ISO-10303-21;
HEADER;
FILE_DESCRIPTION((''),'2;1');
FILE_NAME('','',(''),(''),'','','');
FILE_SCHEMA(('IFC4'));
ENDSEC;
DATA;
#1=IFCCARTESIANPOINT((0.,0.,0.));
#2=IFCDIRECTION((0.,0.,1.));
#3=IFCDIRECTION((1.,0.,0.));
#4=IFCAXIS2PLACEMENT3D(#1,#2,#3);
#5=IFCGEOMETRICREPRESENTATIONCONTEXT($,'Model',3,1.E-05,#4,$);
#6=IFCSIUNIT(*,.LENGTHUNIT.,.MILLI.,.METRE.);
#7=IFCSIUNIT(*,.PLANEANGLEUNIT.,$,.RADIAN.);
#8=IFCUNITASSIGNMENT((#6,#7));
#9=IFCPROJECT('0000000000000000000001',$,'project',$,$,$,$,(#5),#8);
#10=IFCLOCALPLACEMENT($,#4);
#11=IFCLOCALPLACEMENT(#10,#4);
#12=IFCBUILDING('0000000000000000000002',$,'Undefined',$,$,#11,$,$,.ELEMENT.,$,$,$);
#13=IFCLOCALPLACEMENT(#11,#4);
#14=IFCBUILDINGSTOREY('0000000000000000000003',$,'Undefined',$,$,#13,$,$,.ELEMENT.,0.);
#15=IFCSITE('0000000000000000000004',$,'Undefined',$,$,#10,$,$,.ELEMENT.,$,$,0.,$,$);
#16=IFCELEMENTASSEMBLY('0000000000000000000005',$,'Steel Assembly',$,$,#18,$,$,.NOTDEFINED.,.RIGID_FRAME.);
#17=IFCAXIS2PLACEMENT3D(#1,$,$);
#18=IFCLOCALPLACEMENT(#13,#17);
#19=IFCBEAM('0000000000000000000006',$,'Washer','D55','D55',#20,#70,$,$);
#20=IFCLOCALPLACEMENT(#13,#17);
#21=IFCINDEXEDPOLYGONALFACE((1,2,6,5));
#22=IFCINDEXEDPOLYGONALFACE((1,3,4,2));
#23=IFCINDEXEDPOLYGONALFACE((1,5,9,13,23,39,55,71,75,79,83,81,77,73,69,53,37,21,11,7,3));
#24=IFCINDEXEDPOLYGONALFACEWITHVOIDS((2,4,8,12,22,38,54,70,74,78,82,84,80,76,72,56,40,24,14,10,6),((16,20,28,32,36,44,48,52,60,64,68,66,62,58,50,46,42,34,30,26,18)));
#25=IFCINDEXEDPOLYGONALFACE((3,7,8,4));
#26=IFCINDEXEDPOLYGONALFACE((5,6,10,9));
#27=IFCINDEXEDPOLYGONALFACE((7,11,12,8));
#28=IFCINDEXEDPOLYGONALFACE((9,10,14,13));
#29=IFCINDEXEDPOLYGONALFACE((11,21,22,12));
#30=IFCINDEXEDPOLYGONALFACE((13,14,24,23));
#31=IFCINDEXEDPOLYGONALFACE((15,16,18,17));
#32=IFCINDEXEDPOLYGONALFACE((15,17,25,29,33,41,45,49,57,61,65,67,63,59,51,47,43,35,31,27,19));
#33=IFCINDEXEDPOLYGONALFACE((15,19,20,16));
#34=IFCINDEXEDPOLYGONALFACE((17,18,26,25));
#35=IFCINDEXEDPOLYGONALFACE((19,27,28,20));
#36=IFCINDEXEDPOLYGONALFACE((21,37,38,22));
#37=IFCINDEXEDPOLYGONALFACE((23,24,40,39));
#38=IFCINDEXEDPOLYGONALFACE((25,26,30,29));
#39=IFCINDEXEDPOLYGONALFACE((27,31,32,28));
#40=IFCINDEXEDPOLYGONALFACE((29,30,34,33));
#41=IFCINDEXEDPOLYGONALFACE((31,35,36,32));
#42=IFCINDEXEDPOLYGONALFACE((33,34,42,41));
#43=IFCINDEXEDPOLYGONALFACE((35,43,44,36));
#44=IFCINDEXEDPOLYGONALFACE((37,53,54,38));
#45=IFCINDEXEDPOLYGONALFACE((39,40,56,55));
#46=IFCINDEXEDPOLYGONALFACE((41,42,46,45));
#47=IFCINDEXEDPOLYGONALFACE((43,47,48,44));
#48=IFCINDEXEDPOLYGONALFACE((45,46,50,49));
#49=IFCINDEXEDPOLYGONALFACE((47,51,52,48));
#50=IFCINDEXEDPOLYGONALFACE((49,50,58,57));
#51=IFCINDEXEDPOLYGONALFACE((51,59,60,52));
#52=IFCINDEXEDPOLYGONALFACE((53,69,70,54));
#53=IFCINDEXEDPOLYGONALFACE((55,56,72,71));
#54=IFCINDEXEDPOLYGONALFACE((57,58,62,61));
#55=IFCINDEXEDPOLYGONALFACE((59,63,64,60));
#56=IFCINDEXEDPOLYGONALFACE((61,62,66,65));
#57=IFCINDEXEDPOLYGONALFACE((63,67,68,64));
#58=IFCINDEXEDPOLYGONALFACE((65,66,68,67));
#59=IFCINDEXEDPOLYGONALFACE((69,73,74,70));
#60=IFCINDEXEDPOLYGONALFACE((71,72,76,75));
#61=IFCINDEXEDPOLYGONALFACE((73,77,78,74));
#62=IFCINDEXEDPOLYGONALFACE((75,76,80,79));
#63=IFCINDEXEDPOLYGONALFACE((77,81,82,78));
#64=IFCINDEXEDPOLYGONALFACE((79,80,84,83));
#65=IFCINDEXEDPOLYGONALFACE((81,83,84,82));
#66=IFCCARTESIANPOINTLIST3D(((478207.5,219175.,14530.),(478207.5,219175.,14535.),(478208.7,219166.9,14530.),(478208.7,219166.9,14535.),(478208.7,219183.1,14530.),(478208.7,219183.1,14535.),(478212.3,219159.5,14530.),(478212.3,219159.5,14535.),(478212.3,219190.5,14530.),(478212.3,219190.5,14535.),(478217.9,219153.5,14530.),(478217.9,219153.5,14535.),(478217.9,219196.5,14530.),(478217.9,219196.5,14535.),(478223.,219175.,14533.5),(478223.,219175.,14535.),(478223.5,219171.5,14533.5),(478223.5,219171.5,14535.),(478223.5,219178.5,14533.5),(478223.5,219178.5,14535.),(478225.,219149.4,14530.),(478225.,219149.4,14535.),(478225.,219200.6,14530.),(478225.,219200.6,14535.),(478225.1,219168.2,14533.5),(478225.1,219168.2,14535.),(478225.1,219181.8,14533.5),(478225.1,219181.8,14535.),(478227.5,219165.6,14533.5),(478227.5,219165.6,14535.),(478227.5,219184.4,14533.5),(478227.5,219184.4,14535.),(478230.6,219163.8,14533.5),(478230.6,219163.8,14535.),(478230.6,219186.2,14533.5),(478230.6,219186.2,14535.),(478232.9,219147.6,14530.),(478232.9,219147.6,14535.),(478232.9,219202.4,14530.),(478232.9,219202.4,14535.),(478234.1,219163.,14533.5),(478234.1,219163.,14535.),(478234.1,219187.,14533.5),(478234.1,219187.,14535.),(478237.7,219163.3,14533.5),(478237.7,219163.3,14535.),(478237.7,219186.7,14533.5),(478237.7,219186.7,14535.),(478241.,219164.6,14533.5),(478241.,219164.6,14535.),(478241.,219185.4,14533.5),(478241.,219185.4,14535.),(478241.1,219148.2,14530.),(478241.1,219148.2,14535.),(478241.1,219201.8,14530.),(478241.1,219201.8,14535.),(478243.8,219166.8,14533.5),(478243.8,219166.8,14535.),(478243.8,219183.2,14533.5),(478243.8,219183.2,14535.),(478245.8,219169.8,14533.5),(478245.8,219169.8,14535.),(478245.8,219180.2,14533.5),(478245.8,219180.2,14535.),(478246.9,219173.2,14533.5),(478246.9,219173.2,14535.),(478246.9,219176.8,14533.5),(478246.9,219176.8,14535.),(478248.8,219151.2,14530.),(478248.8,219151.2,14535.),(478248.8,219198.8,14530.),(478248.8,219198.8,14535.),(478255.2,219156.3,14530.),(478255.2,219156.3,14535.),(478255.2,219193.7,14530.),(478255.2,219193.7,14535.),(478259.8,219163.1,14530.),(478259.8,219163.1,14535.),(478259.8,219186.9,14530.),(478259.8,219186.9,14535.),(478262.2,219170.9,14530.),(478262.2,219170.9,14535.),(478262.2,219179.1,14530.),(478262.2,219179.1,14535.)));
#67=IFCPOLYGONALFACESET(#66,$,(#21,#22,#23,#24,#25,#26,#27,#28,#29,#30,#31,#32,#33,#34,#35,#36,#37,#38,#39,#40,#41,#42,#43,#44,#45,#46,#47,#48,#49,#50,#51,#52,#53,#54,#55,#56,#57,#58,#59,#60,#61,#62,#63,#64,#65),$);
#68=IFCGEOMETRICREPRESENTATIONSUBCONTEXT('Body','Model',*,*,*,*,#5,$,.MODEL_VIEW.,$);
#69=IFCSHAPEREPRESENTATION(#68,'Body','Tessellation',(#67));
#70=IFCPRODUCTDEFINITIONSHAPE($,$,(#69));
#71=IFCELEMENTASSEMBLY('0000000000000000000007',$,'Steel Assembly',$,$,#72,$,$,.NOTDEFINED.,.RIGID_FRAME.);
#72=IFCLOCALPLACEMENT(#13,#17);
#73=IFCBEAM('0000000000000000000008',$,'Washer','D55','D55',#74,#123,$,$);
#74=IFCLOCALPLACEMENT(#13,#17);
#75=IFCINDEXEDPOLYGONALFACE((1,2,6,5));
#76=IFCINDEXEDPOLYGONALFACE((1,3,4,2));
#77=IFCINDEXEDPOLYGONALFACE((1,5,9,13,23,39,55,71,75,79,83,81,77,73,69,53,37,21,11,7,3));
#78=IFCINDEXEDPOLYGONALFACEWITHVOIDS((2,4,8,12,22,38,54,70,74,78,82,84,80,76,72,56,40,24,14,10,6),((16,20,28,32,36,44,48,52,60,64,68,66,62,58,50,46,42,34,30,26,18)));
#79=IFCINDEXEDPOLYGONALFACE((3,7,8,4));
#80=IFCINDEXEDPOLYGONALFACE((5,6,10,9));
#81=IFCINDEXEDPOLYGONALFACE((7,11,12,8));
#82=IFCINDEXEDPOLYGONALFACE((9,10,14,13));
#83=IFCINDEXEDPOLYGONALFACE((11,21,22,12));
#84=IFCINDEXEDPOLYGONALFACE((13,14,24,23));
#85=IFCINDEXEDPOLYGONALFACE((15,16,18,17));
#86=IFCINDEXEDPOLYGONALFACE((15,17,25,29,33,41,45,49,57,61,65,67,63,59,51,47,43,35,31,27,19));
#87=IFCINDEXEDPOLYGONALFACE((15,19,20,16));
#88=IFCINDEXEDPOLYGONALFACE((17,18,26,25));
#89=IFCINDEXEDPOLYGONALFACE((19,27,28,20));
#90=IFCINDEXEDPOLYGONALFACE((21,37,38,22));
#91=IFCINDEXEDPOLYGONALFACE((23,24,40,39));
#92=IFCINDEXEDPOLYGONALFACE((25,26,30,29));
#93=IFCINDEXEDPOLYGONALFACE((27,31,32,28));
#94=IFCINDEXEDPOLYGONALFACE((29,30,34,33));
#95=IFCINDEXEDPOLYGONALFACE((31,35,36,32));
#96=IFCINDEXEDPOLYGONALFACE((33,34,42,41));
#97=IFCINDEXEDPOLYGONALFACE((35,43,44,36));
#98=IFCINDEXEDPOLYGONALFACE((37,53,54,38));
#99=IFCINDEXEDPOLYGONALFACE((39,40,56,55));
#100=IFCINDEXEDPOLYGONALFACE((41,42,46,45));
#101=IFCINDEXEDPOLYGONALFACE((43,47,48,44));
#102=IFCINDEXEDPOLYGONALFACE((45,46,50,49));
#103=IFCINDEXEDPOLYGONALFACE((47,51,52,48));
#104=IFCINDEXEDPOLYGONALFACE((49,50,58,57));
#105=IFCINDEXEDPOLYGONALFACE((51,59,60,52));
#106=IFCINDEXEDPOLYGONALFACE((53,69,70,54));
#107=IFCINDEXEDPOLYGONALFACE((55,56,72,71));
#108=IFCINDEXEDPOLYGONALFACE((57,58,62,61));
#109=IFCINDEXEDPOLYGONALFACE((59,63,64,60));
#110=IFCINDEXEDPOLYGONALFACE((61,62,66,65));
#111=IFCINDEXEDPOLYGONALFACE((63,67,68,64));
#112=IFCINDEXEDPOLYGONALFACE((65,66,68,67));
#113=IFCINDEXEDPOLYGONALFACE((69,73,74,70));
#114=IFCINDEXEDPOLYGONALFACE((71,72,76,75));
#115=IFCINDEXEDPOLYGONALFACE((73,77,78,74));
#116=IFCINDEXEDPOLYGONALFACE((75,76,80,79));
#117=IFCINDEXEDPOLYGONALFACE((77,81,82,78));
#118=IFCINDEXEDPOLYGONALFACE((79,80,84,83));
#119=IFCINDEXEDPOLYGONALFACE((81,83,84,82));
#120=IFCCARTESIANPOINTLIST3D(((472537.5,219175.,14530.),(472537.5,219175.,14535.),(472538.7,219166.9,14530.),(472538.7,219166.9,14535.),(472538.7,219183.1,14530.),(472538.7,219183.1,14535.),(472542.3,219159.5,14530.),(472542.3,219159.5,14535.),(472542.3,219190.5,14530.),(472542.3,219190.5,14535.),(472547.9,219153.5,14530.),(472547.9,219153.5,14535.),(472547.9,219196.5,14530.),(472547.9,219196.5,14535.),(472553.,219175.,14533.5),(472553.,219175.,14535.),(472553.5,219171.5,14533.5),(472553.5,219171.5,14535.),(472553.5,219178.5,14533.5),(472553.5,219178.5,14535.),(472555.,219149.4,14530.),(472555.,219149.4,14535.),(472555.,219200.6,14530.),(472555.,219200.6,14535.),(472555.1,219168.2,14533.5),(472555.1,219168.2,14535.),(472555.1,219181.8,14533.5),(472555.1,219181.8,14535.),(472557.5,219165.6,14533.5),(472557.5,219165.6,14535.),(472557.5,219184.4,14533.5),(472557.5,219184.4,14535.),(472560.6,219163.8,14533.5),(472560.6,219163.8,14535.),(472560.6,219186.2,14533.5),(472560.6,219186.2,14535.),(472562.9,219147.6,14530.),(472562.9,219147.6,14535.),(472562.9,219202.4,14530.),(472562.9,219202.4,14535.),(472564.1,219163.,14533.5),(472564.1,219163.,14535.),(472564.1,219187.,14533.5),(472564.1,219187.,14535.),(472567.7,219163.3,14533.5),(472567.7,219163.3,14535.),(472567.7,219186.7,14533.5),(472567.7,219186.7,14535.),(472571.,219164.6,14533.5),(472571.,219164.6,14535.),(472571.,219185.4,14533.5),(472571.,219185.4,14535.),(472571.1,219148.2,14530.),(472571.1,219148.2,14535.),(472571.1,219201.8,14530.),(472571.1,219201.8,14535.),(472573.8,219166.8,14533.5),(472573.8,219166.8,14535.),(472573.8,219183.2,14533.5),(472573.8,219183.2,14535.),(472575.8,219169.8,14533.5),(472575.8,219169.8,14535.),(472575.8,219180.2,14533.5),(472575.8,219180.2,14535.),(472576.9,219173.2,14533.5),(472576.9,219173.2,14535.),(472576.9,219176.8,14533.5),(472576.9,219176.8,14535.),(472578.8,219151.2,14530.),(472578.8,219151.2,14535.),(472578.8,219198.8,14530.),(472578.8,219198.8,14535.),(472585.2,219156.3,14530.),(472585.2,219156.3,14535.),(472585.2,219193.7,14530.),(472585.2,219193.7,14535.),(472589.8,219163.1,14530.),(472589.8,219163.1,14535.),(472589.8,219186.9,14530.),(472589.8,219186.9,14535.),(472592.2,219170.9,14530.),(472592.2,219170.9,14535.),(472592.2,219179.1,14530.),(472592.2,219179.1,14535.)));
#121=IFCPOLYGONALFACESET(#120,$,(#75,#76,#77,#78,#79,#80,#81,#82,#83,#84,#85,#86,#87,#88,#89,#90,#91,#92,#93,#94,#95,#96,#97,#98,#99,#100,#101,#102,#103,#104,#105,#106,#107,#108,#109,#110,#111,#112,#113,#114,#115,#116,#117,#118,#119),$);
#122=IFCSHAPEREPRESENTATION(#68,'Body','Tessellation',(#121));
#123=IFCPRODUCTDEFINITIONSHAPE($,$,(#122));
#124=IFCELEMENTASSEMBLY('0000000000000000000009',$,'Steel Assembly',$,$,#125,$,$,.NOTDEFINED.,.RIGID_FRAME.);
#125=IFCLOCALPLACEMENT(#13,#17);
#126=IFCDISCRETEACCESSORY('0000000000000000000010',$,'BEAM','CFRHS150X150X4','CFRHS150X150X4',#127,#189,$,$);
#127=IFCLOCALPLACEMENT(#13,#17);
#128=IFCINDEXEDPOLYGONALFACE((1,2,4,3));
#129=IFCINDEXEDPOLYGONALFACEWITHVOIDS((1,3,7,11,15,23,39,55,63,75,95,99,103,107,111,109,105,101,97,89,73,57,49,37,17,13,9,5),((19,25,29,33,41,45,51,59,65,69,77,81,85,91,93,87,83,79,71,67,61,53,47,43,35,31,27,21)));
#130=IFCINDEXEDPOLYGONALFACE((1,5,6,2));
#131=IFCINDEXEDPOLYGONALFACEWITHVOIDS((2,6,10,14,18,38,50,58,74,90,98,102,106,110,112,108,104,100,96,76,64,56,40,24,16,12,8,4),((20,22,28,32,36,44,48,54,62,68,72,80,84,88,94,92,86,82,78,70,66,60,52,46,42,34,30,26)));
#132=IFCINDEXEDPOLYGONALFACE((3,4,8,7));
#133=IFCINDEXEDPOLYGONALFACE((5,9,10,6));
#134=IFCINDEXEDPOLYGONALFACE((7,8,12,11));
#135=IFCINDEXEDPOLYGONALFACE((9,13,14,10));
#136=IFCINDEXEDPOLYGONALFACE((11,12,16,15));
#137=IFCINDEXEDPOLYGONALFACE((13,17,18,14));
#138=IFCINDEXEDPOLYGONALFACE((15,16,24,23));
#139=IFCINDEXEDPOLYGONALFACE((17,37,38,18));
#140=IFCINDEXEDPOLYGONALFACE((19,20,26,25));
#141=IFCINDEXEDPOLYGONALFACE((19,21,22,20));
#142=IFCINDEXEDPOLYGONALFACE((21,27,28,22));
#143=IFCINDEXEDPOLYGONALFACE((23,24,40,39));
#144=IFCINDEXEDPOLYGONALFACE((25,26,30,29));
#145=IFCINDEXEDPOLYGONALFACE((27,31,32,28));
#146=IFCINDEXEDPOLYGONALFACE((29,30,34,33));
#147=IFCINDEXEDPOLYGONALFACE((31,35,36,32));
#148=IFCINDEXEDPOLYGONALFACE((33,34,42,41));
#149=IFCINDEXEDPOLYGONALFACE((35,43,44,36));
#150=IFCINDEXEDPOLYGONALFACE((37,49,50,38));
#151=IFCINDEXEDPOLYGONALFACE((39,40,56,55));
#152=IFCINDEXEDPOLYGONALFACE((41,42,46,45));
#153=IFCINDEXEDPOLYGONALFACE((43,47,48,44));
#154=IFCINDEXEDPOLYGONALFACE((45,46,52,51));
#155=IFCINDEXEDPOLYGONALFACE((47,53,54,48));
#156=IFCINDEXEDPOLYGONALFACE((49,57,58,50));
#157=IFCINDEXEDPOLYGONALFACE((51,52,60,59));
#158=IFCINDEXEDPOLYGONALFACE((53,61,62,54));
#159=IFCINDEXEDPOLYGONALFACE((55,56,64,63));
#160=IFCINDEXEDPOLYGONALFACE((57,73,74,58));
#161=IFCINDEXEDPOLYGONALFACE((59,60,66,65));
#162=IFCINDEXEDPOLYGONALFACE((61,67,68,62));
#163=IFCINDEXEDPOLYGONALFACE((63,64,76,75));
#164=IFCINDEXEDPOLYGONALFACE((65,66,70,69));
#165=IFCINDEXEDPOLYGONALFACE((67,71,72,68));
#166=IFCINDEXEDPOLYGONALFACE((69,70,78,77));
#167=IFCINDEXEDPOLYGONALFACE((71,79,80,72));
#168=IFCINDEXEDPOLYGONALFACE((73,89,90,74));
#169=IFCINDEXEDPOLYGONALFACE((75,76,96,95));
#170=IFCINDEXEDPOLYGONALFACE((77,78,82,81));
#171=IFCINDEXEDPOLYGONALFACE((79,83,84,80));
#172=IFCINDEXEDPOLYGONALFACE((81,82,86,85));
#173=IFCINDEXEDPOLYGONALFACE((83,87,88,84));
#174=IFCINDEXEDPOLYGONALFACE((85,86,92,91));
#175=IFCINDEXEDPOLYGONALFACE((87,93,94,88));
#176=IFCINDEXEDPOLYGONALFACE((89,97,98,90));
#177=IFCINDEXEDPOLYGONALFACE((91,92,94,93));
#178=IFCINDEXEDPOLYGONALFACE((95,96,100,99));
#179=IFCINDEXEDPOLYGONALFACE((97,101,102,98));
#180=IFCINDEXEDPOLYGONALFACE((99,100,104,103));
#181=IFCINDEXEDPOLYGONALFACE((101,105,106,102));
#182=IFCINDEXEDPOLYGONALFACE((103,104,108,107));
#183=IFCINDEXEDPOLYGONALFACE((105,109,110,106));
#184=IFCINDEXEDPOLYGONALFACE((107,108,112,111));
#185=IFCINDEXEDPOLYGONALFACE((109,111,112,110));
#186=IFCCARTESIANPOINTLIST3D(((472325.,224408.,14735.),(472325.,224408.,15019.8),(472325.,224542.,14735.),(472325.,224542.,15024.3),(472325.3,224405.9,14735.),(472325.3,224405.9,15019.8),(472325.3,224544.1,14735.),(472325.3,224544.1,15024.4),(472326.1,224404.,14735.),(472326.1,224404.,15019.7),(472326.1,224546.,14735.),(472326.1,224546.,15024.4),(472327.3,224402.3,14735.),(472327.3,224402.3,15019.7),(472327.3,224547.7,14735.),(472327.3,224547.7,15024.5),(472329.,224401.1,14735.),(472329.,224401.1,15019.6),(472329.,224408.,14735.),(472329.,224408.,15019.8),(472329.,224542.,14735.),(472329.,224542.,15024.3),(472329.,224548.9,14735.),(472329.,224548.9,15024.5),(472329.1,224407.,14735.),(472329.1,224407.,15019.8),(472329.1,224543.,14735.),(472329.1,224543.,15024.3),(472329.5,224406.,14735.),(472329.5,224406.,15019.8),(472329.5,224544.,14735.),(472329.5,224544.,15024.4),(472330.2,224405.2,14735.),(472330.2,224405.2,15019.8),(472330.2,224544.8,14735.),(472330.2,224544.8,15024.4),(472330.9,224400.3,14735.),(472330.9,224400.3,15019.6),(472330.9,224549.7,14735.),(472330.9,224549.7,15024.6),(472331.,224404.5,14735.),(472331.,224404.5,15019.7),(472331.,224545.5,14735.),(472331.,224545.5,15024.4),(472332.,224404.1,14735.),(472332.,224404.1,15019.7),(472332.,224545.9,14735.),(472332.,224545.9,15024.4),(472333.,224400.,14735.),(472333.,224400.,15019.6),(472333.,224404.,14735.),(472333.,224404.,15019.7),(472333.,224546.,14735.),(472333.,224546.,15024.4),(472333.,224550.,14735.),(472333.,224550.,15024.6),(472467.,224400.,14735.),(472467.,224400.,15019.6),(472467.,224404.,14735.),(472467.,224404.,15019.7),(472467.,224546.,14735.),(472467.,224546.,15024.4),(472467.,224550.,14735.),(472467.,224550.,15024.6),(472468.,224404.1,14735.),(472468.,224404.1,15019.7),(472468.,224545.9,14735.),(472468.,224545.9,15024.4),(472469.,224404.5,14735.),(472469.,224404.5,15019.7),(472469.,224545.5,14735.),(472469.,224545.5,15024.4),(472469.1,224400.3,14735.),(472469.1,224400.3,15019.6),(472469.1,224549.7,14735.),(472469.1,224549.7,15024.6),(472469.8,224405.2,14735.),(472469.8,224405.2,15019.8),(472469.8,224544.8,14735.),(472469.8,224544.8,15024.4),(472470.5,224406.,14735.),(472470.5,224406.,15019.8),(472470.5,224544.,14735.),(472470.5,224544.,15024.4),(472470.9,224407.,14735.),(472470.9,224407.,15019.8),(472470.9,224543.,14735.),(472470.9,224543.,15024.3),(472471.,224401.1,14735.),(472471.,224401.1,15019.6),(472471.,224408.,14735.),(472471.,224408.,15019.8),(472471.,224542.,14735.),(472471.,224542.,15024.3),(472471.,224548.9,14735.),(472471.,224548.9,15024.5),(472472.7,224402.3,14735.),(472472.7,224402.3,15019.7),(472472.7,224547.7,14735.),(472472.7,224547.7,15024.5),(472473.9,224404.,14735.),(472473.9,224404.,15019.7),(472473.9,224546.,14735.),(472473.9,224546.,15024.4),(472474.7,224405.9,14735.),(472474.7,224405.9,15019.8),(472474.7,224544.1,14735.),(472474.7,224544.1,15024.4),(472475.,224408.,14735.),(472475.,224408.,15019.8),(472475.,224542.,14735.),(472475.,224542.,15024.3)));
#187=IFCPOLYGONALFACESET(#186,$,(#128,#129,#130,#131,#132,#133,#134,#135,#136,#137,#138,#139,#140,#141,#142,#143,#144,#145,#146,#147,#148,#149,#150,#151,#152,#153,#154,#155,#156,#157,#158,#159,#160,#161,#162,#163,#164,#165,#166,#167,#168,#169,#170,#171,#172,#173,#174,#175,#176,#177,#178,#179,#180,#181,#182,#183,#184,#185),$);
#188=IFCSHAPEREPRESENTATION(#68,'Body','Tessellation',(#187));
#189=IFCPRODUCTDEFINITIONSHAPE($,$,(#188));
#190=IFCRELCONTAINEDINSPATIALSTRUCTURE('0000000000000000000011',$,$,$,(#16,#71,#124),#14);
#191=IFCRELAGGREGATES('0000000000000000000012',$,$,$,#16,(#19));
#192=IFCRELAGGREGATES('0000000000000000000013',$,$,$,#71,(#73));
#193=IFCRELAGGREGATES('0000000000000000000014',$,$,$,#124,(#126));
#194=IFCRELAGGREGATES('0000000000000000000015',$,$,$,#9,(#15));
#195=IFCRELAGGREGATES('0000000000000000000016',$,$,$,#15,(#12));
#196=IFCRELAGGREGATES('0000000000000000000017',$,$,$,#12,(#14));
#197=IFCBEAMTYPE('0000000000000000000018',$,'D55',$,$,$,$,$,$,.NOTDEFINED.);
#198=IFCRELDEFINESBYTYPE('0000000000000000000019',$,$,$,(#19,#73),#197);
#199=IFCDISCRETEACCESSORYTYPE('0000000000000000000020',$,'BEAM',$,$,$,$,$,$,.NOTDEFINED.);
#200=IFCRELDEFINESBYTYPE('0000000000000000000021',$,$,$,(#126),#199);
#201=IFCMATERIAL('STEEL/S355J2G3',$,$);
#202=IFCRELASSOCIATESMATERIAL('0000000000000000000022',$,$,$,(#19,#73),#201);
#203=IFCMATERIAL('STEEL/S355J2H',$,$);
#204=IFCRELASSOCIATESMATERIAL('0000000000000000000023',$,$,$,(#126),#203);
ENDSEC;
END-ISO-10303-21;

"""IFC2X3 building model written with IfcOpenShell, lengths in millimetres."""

from ifc_helpers import new_model, si_unit, frame, origin_with_axes, origin_2d_with_axis, place, context, subcontext, project, spatial, hollow_rectangle, circle, extrude, boolean, clip, halfspace, material, type_object, element, aggregate, save


model = new_model("IFC2X3")

# Units and contexts
model_context = context("Model", 3, precision=1e-05, world=origin_with_axes())
body_context = subcontext(model_context, "Body", "Model", "MODEL_VIEW")
ifc_project = project(units=[si_unit("LENGTHUNIT", "METRE", prefix="MILLI"), si_unit("PLANEANGLEUNIT", "RADIAN")], contexts=[model_context])

# Site, building, storey
site_placement = place(None, origin_with_axes())
site = spatial("IfcSite", under=ifc_project, at=site_placement, Name="Undefined", CompositionType="ELEMENT", RefElevation=0.0)
building_placement = place(site_placement, origin_with_axes())
building = spatial("IfcBuilding", under=site, at=building_placement, Name="Undefined", CompositionType="ELEMENT")
storey_placement = place(building_placement, origin_with_axes())
storey = spatial("IfcBuildingStorey", under=building, at=storey_placement, Name="Undefined", CompositionType="ELEMENT", Elevation=0.0)

# Element assemblies, beams
ifc_material_1 = material(Name="STEEL/S355J2G3")
beam_type_1 = type_object("IfcBeamType", Name="D55", PredefinedType="NOTDEFINED")
assembly_1_placement = place(storey_placement, origin_with_axes())
assembly_1 = element("IfcElementAssembly", 1, at=assembly_1_placement, inside=storey, Name="Steel Assembly", AssemblyPlace="NOTDEFINED", PredefinedType="RIGID_FRAME")
beam_1_placement = place(assembly_1_placement, frame((478235.0, 219175.0, 14535.0), z_axis=(0.0, -1.0, 0.0), x_axis=(0.0, 0.0, -1.0)))
beam_1 = element("IfcBeam", 2, at=beam_1_placement, type_object=beam_type_1, material=ifc_material_1, Name="Washer", Description="D55", ObjectType="D55", context=body_context, shape_type="CSG", body=[
    boolean("DIFFERENCE", extrude(circle(Radius=27.5, at=origin_2d_with_axis()), frame((5.0, 0.0, 0.0), z_axis=(-1.0, 0.0, 0.0), x_axis=(0.0, -1.0, 0.0)), (0.0, 0.0, 1.0), 5.0), extrude(circle(Radius=12.0, at=origin_2d_with_axis()), frame((1.5, 0.0, 0.0), z_axis=(-1.0, 0.0, 0.0), x_axis=(0.0, -1.0, 0.0)), (0.0, 0.0, 1.0), 10.0)),
])
aggregate(assembly_1, [beam_1])
assembly_2_placement = place(storey_placement, origin_with_axes())
assembly_2 = element("IfcElementAssembly", 3, at=assembly_2_placement, inside=storey, Name="Steel Assembly", AssemblyPlace="NOTDEFINED", PredefinedType="RIGID_FRAME")
beam_2_placement = place(assembly_2_placement, frame((472565.0, 219175.0, 14535.0), z_axis=(0.0, -1.0, 0.0), x_axis=(0.0, 0.0, -1.0)))
beam_2 = element("IfcBeam", 4, at=beam_2_placement, type_object=beam_type_1, material=ifc_material_1, Name="Washer", Description="D55", ObjectType="D55", context=body_context, shape_type="CSG", body=[
    boolean("DIFFERENCE", extrude(circle(Radius=27.5, at=origin_2d_with_axis()), frame((5.0, 0.0, 0.0), z_axis=(-1.0, 0.0, 0.0), x_axis=(0.0, -1.0, 0.0)), (0.0, 0.0, 1.0), 5.0), extrude(circle(Radius=12.0, at=origin_2d_with_axis()), frame((1.5, 0.0, 0.0), z_axis=(-1.0, 0.0, 0.0), x_axis=(0.0, -1.0, 0.0)), (0.0, 0.0, 1.0), 10.0)),
])
aggregate(assembly_2, [beam_2])

# Element assembly, discrete accessory
ifc_material_2 = material(Name="STEEL/S355J2H")
discrete_accessory_type_1 = type_object("IfcDiscreteAccessoryType", Name="BEAM")
assembly_3_placement = place(storey_placement, origin_with_axes())
assembly_3 = element("IfcElementAssembly", 5, at=assembly_3_placement, inside=storey, Name="Steel Assembly", AssemblyPlace="NOTDEFINED", PredefinedType="RIGID_FRAME")
discrete_accessory_1_placement = place(assembly_3_placement, frame((472400.0, 224475.0, 14720.0), z_axis=(0.0, 0.0, 1.0), x_axis=(1.0, 0.0, 0.0)))
discrete_accessory_1 = element("IfcDiscreteAccessory", 6, at=discrete_accessory_1_placement, type_object=discrete_accessory_type_1, material=ifc_material_2, Name="BEAM", Description="CFRHS150X150X4", ObjectType="CFRHS150X150X4", context=body_context, shape_type="Clipping", body=[
    clip(extrude(hollow_rectangle(XDim=150.0, YDim=150.0, WallThickness=4.0, InnerFilletRadius=4.0, OuterFilletRadius=8.0, at=origin_2d_with_axis()), frame((0.0, 0.0, 304.6), z_axis=(0.0, 0.0, -1.0), x_axis=(0.0, -1.0, 0.0)), (0.0, 0.0, 1.0), 289.6), halfspace(frame((-1000.0, 2.7, 302.2), z_axis=(0.0, 0.033315, -0.999445), x_axis=(0.0, -0.999445, -0.033315)), True)),
])

aggregate(assembly_3, [discrete_accessory_1])

save(model, "model.ifc")
